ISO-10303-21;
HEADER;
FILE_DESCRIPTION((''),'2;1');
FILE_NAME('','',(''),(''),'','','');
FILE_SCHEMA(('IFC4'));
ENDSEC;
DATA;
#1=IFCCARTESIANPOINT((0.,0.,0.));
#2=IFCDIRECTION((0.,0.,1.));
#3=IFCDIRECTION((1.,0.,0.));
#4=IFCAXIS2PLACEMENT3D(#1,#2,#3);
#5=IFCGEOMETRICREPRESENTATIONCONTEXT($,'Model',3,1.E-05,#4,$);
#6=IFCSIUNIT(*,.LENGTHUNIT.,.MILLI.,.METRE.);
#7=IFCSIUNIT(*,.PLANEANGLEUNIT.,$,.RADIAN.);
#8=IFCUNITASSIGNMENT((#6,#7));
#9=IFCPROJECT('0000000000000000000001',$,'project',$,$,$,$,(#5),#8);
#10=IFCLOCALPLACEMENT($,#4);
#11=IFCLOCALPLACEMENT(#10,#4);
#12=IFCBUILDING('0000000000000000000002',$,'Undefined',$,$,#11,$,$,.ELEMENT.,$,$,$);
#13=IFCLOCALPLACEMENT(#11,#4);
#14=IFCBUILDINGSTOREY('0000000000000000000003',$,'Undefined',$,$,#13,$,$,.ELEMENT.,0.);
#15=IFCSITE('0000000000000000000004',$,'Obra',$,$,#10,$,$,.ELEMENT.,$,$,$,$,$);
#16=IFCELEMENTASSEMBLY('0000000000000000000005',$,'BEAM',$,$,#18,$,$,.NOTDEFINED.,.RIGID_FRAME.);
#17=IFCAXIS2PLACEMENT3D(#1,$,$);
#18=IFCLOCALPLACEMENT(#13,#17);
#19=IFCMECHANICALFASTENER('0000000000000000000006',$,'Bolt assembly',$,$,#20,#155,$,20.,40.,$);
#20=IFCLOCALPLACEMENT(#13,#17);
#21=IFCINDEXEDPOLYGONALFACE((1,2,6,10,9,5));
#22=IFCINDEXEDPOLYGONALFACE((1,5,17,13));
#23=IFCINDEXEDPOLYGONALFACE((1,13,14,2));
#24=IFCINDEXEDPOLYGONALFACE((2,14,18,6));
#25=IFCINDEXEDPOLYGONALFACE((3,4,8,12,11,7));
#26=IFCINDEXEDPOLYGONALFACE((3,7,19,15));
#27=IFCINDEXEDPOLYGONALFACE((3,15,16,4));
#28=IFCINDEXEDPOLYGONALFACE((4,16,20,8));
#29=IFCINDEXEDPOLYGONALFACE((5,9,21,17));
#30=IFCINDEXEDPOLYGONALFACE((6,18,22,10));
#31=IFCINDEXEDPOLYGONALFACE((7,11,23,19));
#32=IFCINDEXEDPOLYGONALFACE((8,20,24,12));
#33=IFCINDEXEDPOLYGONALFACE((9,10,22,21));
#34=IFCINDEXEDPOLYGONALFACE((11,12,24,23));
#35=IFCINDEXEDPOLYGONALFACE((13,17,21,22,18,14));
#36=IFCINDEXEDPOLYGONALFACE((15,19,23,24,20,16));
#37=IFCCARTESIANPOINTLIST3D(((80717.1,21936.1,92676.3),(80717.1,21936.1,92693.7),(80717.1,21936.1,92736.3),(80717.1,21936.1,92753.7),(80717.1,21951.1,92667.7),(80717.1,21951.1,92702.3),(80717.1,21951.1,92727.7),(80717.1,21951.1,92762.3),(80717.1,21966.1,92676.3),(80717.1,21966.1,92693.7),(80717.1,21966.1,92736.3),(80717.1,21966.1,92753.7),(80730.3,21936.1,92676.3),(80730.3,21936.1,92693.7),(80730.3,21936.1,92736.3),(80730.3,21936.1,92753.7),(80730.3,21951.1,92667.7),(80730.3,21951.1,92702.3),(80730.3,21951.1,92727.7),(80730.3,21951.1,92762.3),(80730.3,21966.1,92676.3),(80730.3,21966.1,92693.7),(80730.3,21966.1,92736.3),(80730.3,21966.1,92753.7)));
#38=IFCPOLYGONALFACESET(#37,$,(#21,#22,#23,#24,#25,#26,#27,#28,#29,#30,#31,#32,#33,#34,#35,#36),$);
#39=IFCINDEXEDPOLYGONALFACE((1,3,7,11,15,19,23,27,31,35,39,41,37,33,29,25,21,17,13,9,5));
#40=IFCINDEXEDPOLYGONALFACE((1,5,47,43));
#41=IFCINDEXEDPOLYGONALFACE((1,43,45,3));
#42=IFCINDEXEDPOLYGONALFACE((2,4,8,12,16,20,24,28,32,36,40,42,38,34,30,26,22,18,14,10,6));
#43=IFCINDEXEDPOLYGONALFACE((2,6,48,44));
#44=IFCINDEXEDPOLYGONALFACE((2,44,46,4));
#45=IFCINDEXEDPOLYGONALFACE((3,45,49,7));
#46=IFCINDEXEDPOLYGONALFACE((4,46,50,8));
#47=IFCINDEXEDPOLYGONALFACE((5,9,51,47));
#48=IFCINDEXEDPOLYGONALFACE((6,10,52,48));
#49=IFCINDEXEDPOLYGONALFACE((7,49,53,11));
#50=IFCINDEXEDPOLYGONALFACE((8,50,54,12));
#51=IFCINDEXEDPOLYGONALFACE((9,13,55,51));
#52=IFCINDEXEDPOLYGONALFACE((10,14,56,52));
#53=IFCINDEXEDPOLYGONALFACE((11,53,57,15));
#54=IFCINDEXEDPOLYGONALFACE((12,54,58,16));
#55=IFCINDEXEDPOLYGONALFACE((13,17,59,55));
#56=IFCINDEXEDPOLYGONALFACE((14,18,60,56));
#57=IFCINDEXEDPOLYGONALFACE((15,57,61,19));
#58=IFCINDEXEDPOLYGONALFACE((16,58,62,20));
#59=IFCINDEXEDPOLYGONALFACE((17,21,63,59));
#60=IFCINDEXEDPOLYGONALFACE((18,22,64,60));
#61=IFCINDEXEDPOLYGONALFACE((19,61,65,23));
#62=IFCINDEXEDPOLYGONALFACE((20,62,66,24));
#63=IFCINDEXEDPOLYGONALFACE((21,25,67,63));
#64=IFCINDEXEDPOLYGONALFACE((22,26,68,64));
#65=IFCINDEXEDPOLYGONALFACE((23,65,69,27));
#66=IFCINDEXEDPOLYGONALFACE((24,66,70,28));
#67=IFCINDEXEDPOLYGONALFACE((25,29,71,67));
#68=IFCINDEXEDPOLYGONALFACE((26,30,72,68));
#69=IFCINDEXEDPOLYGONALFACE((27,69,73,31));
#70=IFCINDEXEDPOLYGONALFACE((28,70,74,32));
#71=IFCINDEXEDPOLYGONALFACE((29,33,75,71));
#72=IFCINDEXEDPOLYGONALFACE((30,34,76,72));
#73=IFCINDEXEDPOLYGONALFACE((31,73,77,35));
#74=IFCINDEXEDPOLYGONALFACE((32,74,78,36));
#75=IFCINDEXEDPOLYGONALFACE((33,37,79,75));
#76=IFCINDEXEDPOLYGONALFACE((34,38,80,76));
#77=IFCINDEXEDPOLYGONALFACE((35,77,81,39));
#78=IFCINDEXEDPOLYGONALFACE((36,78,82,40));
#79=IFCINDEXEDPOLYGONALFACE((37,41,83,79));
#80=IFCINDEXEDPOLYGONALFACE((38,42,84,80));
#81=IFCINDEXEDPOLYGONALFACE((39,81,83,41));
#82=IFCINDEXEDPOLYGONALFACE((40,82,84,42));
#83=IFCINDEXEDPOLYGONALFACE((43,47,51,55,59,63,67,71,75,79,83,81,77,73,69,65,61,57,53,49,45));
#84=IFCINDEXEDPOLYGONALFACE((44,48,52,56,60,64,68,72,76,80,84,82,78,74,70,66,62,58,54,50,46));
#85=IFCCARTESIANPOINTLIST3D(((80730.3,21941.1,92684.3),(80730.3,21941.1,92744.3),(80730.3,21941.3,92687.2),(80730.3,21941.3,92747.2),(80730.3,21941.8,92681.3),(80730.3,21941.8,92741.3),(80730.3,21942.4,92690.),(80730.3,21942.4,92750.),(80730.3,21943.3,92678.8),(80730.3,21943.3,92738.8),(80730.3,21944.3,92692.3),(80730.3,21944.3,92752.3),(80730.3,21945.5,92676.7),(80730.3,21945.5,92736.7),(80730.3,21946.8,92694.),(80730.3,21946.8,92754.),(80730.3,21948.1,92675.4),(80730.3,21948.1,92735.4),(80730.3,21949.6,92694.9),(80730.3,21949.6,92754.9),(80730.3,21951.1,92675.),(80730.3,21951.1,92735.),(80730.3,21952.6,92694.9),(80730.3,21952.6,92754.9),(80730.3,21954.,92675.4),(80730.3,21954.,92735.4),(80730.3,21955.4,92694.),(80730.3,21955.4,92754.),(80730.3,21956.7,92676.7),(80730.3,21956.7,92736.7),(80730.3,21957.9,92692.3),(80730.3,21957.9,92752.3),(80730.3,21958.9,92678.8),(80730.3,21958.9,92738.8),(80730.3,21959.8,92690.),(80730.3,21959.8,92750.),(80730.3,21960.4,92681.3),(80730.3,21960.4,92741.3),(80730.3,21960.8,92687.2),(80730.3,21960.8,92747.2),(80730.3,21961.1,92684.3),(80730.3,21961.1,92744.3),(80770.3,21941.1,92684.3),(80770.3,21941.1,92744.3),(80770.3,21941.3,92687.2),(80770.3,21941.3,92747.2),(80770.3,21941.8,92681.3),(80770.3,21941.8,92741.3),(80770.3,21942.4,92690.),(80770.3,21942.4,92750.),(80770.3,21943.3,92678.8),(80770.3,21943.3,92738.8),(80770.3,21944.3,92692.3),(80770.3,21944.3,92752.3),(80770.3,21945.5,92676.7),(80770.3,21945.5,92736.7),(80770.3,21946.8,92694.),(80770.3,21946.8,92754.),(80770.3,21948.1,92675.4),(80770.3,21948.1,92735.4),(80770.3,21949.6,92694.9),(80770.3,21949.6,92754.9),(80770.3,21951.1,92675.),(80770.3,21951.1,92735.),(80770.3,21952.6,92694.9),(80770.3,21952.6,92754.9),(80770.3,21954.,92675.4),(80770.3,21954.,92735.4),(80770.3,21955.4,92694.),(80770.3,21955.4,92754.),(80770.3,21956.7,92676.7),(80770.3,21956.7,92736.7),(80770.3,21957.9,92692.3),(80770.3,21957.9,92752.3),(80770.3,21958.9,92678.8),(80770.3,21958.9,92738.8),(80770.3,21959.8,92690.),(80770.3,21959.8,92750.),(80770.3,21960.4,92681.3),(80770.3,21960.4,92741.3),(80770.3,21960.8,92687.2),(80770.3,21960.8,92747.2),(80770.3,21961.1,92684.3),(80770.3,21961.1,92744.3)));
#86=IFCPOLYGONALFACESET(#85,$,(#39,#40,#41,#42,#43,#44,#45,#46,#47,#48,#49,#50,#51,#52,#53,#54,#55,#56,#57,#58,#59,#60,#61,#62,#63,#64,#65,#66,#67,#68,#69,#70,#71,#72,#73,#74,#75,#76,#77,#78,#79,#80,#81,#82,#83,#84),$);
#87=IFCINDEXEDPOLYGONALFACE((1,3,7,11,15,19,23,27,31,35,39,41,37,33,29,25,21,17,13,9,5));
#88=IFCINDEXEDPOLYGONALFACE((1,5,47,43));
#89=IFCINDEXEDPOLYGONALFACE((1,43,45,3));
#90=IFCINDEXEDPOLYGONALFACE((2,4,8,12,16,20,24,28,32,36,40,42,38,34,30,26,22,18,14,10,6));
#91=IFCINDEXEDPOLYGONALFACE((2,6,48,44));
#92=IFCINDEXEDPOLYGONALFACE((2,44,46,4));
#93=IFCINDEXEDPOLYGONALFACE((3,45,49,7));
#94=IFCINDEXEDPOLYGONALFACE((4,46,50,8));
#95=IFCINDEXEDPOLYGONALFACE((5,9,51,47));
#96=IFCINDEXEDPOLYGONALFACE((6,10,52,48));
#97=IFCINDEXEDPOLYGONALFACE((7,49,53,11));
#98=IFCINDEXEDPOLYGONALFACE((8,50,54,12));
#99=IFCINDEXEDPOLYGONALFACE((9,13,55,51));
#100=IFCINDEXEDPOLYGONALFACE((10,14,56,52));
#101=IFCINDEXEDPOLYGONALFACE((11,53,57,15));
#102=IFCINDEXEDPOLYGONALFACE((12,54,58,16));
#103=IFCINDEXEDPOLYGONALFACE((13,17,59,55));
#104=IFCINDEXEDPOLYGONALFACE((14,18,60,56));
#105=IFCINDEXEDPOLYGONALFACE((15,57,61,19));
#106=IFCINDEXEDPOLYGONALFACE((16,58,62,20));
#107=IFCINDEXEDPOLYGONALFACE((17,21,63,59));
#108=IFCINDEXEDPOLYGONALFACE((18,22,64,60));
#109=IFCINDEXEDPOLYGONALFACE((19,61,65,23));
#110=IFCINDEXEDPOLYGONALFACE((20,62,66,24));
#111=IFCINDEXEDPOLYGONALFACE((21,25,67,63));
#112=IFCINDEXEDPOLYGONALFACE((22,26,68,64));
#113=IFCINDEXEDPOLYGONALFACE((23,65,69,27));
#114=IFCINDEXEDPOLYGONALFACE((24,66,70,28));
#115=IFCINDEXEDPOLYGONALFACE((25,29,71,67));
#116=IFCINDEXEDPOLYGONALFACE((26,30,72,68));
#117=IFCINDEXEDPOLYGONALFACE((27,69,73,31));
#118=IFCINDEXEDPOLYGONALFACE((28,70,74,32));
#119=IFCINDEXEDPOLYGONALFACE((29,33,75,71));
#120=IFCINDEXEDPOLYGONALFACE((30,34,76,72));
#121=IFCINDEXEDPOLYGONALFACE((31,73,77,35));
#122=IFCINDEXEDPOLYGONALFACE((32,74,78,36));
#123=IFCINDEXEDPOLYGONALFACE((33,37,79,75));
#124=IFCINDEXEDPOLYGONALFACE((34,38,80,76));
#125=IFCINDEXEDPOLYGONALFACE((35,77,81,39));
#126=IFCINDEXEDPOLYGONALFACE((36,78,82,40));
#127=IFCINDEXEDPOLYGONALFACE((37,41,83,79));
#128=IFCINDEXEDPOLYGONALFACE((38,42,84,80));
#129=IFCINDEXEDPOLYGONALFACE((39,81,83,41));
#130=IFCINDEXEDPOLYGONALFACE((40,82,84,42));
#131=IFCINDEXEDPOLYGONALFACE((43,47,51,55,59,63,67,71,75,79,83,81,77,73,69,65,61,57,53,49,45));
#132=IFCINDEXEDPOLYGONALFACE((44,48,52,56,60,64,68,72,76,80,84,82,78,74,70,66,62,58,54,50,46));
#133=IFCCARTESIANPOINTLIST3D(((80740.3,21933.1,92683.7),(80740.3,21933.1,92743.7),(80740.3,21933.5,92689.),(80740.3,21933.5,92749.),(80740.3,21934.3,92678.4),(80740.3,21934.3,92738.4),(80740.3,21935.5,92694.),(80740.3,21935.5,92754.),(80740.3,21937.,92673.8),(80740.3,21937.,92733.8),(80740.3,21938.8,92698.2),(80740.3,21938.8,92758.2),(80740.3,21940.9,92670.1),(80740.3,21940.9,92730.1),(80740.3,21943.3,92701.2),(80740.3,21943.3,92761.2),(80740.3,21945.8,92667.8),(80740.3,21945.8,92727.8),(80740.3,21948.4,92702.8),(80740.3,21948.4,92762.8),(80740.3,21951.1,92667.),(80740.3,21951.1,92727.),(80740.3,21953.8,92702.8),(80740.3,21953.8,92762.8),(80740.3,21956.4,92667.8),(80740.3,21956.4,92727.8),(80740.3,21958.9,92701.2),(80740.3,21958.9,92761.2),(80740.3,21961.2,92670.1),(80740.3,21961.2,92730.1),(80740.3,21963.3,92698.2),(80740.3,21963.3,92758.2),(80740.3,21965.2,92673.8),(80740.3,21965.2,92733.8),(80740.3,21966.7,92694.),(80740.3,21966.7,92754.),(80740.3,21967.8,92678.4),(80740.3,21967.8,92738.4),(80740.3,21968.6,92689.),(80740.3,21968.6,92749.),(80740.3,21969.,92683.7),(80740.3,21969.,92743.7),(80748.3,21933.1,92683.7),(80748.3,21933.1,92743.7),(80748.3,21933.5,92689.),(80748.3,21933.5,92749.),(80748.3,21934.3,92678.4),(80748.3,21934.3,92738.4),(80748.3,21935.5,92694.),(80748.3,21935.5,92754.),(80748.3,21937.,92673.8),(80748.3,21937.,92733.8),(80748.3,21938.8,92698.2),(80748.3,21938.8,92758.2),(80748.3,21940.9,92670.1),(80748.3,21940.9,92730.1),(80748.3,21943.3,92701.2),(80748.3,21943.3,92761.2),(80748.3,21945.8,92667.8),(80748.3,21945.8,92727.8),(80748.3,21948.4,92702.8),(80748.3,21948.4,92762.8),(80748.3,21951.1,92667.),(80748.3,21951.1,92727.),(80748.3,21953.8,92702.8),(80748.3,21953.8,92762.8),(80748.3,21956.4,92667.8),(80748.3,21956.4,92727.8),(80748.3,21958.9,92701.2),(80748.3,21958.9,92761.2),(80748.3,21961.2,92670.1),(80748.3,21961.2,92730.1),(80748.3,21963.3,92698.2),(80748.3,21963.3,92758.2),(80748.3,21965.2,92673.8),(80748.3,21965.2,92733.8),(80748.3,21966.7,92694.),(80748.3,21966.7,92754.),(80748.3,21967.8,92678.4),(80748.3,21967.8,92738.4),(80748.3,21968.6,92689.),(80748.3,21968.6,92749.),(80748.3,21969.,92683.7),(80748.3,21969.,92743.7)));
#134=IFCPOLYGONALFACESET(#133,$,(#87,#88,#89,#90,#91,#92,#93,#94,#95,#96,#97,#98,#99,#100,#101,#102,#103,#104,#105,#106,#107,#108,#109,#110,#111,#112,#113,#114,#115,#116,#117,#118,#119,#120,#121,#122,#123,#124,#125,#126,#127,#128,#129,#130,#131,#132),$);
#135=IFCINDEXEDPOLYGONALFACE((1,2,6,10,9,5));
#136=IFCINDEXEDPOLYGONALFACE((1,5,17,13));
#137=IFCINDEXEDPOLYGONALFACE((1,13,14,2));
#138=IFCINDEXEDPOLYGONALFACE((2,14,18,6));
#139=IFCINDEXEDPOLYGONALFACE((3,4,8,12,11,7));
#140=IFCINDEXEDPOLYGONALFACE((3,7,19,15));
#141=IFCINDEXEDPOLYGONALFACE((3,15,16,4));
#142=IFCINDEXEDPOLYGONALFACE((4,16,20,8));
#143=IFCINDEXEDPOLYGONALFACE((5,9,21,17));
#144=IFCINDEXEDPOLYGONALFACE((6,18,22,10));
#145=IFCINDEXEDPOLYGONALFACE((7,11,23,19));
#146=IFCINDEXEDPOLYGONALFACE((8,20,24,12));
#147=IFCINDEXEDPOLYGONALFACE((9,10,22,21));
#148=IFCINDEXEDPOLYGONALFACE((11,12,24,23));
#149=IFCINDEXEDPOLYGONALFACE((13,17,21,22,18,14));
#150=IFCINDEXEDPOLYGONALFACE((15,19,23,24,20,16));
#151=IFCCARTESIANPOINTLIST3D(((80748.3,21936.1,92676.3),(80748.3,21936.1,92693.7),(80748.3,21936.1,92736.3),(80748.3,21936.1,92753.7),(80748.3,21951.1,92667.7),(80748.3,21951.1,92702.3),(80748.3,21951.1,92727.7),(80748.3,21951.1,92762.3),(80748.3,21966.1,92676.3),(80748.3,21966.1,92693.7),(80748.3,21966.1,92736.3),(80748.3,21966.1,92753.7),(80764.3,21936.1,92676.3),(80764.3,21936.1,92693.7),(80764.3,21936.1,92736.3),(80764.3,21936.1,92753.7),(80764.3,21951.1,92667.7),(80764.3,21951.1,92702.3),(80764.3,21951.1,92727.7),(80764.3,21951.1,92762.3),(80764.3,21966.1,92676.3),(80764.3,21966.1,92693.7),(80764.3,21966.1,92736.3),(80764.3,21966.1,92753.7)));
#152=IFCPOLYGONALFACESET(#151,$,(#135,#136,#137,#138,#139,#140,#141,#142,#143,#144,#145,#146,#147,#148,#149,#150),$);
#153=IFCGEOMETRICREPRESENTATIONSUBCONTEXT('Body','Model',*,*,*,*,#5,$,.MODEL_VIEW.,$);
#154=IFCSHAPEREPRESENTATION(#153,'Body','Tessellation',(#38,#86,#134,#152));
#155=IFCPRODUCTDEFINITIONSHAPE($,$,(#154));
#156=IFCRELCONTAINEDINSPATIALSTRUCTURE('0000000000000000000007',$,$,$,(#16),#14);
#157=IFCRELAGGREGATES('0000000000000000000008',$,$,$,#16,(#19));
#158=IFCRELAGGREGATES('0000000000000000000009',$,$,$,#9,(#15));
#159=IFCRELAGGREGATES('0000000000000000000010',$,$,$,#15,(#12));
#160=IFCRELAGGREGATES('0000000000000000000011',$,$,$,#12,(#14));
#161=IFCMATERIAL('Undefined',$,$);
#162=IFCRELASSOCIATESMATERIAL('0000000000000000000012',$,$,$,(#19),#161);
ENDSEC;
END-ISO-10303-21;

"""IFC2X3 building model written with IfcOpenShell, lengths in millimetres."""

from ifc_helpers import new_model, si_unit, frame, origin_with_axes, origin_2d_with_axis, place, context, subcontext, project, spatial, polyline, circle, outline, extrude, source, transform, mapped, material, element, aggregate, save


model = new_model("IFC2X3")

# Units and contexts
model_context = context("Model", 3, precision=1e-05, world=origin_with_axes())
body_context = subcontext(model_context, "Body", "Model", "MODEL_VIEW")
ifc_project = project(units=[si_unit("LENGTHUNIT", "METRE", prefix="MILLI"), si_unit("PLANEANGLEUNIT", "RADIAN")], contexts=[model_context])

# Site, building, storey
site_placement = place(None, origin_with_axes())
site = spatial("IfcSite", under=ifc_project, at=site_placement, Name="Obra", CompositionType="ELEMENT")
building_placement = place(site_placement, origin_with_axes())
building = spatial("IfcBuilding", under=site, at=building_placement, Name="Undefined", CompositionType="ELEMENT")
storey_placement = place(building_placement, origin_with_axes())
storey = spatial("IfcBuildingStorey", under=building, at=storey_placement, Name="Undefined", CompositionType="ELEMENT", Elevation=0.0)

# Element assembly
ifc_material_1 = material(Name="Undefined")
assembly_1_placement = place(storey_placement, origin_with_axes())
assembly_1 = element("IfcElementAssembly", 1, at=assembly_1_placement, inside=storey, Name="BEAM", AssemblyPlace="NOTDEFINED", PredefinedType="RIGID_FRAME")

# Mechanical fastener
shared_shape_1 = source(origin_with_axes(), body_context, "Body", "SweptSolid", [
    extrude(outline(polyline([(17.3, 0.0), (8.7, 15.0), (-8.7, 15.0), (-17.3, 0.0), (-8.7, -15.0), (8.7, -15.0), (17.3, 0.0)])), frame((0.0, -18.2, 0.0), z_axis=(0.0, 1.0, 0.0), x_axis=(1.0, 0.0, 0.0)), (0.0, 0.0, 1.0), 13.2),
    extrude(circle(Radius=10.0, at=origin_2d_with_axis()), frame((0.0, -5.0, 0.0), z_axis=(0.0, 1.0, 0.0), x_axis=(1.0, 0.0, 0.0)), (0.0, 0.0, 1.0), 40.0),
    extrude(circle(Radius=18.0, at=origin_2d_with_axis()), frame((0.0, 5.0, 0.0), z_axis=(0.0, 1.0, 0.0), x_axis=(1.0, 0.0, 0.0)), (0.0, 0.0, 1.0), 8.0),
    extrude(outline(polyline([(17.3, 0.0), (8.7, 15.0), (-8.7, 15.0), (-17.3, 0.0), (-8.7, -15.0), (8.7, -15.0), (17.3, 0.0)])), frame((0.0, 13.0, 0.0), z_axis=(0.0, 1.0, 0.0), x_axis=(1.0, 0.0, 0.0)), (0.0, 0.0, 1.0), 16.0),
])
mechanical_fastener_1_placement = place(assembly_1_placement, frame((80735.3, 21991.1, 92850.0), z_axis=(0.0, -1.0, 0.0), x_axis=(0.0, 0.0, -1.0)))
mechanical_fastener_1 = element("IfcMechanicalFastener", 2, at=mechanical_fastener_1_placement, material=ifc_material_1, Name="Bolt assembly", NominalDiameter=20.0, NominalLength=40.0, context=body_context, shape_type="MappedRepresentation", body=[
    mapped(shared_shape_1, transform((105.0, 0.0, 40.0))),
    mapped(shared_shape_1, transform((165.0, 0.0, 40.0))),
])
aggregate(assembly_1, [mechanical_fastener_1])

save(model, "model.ifc")
